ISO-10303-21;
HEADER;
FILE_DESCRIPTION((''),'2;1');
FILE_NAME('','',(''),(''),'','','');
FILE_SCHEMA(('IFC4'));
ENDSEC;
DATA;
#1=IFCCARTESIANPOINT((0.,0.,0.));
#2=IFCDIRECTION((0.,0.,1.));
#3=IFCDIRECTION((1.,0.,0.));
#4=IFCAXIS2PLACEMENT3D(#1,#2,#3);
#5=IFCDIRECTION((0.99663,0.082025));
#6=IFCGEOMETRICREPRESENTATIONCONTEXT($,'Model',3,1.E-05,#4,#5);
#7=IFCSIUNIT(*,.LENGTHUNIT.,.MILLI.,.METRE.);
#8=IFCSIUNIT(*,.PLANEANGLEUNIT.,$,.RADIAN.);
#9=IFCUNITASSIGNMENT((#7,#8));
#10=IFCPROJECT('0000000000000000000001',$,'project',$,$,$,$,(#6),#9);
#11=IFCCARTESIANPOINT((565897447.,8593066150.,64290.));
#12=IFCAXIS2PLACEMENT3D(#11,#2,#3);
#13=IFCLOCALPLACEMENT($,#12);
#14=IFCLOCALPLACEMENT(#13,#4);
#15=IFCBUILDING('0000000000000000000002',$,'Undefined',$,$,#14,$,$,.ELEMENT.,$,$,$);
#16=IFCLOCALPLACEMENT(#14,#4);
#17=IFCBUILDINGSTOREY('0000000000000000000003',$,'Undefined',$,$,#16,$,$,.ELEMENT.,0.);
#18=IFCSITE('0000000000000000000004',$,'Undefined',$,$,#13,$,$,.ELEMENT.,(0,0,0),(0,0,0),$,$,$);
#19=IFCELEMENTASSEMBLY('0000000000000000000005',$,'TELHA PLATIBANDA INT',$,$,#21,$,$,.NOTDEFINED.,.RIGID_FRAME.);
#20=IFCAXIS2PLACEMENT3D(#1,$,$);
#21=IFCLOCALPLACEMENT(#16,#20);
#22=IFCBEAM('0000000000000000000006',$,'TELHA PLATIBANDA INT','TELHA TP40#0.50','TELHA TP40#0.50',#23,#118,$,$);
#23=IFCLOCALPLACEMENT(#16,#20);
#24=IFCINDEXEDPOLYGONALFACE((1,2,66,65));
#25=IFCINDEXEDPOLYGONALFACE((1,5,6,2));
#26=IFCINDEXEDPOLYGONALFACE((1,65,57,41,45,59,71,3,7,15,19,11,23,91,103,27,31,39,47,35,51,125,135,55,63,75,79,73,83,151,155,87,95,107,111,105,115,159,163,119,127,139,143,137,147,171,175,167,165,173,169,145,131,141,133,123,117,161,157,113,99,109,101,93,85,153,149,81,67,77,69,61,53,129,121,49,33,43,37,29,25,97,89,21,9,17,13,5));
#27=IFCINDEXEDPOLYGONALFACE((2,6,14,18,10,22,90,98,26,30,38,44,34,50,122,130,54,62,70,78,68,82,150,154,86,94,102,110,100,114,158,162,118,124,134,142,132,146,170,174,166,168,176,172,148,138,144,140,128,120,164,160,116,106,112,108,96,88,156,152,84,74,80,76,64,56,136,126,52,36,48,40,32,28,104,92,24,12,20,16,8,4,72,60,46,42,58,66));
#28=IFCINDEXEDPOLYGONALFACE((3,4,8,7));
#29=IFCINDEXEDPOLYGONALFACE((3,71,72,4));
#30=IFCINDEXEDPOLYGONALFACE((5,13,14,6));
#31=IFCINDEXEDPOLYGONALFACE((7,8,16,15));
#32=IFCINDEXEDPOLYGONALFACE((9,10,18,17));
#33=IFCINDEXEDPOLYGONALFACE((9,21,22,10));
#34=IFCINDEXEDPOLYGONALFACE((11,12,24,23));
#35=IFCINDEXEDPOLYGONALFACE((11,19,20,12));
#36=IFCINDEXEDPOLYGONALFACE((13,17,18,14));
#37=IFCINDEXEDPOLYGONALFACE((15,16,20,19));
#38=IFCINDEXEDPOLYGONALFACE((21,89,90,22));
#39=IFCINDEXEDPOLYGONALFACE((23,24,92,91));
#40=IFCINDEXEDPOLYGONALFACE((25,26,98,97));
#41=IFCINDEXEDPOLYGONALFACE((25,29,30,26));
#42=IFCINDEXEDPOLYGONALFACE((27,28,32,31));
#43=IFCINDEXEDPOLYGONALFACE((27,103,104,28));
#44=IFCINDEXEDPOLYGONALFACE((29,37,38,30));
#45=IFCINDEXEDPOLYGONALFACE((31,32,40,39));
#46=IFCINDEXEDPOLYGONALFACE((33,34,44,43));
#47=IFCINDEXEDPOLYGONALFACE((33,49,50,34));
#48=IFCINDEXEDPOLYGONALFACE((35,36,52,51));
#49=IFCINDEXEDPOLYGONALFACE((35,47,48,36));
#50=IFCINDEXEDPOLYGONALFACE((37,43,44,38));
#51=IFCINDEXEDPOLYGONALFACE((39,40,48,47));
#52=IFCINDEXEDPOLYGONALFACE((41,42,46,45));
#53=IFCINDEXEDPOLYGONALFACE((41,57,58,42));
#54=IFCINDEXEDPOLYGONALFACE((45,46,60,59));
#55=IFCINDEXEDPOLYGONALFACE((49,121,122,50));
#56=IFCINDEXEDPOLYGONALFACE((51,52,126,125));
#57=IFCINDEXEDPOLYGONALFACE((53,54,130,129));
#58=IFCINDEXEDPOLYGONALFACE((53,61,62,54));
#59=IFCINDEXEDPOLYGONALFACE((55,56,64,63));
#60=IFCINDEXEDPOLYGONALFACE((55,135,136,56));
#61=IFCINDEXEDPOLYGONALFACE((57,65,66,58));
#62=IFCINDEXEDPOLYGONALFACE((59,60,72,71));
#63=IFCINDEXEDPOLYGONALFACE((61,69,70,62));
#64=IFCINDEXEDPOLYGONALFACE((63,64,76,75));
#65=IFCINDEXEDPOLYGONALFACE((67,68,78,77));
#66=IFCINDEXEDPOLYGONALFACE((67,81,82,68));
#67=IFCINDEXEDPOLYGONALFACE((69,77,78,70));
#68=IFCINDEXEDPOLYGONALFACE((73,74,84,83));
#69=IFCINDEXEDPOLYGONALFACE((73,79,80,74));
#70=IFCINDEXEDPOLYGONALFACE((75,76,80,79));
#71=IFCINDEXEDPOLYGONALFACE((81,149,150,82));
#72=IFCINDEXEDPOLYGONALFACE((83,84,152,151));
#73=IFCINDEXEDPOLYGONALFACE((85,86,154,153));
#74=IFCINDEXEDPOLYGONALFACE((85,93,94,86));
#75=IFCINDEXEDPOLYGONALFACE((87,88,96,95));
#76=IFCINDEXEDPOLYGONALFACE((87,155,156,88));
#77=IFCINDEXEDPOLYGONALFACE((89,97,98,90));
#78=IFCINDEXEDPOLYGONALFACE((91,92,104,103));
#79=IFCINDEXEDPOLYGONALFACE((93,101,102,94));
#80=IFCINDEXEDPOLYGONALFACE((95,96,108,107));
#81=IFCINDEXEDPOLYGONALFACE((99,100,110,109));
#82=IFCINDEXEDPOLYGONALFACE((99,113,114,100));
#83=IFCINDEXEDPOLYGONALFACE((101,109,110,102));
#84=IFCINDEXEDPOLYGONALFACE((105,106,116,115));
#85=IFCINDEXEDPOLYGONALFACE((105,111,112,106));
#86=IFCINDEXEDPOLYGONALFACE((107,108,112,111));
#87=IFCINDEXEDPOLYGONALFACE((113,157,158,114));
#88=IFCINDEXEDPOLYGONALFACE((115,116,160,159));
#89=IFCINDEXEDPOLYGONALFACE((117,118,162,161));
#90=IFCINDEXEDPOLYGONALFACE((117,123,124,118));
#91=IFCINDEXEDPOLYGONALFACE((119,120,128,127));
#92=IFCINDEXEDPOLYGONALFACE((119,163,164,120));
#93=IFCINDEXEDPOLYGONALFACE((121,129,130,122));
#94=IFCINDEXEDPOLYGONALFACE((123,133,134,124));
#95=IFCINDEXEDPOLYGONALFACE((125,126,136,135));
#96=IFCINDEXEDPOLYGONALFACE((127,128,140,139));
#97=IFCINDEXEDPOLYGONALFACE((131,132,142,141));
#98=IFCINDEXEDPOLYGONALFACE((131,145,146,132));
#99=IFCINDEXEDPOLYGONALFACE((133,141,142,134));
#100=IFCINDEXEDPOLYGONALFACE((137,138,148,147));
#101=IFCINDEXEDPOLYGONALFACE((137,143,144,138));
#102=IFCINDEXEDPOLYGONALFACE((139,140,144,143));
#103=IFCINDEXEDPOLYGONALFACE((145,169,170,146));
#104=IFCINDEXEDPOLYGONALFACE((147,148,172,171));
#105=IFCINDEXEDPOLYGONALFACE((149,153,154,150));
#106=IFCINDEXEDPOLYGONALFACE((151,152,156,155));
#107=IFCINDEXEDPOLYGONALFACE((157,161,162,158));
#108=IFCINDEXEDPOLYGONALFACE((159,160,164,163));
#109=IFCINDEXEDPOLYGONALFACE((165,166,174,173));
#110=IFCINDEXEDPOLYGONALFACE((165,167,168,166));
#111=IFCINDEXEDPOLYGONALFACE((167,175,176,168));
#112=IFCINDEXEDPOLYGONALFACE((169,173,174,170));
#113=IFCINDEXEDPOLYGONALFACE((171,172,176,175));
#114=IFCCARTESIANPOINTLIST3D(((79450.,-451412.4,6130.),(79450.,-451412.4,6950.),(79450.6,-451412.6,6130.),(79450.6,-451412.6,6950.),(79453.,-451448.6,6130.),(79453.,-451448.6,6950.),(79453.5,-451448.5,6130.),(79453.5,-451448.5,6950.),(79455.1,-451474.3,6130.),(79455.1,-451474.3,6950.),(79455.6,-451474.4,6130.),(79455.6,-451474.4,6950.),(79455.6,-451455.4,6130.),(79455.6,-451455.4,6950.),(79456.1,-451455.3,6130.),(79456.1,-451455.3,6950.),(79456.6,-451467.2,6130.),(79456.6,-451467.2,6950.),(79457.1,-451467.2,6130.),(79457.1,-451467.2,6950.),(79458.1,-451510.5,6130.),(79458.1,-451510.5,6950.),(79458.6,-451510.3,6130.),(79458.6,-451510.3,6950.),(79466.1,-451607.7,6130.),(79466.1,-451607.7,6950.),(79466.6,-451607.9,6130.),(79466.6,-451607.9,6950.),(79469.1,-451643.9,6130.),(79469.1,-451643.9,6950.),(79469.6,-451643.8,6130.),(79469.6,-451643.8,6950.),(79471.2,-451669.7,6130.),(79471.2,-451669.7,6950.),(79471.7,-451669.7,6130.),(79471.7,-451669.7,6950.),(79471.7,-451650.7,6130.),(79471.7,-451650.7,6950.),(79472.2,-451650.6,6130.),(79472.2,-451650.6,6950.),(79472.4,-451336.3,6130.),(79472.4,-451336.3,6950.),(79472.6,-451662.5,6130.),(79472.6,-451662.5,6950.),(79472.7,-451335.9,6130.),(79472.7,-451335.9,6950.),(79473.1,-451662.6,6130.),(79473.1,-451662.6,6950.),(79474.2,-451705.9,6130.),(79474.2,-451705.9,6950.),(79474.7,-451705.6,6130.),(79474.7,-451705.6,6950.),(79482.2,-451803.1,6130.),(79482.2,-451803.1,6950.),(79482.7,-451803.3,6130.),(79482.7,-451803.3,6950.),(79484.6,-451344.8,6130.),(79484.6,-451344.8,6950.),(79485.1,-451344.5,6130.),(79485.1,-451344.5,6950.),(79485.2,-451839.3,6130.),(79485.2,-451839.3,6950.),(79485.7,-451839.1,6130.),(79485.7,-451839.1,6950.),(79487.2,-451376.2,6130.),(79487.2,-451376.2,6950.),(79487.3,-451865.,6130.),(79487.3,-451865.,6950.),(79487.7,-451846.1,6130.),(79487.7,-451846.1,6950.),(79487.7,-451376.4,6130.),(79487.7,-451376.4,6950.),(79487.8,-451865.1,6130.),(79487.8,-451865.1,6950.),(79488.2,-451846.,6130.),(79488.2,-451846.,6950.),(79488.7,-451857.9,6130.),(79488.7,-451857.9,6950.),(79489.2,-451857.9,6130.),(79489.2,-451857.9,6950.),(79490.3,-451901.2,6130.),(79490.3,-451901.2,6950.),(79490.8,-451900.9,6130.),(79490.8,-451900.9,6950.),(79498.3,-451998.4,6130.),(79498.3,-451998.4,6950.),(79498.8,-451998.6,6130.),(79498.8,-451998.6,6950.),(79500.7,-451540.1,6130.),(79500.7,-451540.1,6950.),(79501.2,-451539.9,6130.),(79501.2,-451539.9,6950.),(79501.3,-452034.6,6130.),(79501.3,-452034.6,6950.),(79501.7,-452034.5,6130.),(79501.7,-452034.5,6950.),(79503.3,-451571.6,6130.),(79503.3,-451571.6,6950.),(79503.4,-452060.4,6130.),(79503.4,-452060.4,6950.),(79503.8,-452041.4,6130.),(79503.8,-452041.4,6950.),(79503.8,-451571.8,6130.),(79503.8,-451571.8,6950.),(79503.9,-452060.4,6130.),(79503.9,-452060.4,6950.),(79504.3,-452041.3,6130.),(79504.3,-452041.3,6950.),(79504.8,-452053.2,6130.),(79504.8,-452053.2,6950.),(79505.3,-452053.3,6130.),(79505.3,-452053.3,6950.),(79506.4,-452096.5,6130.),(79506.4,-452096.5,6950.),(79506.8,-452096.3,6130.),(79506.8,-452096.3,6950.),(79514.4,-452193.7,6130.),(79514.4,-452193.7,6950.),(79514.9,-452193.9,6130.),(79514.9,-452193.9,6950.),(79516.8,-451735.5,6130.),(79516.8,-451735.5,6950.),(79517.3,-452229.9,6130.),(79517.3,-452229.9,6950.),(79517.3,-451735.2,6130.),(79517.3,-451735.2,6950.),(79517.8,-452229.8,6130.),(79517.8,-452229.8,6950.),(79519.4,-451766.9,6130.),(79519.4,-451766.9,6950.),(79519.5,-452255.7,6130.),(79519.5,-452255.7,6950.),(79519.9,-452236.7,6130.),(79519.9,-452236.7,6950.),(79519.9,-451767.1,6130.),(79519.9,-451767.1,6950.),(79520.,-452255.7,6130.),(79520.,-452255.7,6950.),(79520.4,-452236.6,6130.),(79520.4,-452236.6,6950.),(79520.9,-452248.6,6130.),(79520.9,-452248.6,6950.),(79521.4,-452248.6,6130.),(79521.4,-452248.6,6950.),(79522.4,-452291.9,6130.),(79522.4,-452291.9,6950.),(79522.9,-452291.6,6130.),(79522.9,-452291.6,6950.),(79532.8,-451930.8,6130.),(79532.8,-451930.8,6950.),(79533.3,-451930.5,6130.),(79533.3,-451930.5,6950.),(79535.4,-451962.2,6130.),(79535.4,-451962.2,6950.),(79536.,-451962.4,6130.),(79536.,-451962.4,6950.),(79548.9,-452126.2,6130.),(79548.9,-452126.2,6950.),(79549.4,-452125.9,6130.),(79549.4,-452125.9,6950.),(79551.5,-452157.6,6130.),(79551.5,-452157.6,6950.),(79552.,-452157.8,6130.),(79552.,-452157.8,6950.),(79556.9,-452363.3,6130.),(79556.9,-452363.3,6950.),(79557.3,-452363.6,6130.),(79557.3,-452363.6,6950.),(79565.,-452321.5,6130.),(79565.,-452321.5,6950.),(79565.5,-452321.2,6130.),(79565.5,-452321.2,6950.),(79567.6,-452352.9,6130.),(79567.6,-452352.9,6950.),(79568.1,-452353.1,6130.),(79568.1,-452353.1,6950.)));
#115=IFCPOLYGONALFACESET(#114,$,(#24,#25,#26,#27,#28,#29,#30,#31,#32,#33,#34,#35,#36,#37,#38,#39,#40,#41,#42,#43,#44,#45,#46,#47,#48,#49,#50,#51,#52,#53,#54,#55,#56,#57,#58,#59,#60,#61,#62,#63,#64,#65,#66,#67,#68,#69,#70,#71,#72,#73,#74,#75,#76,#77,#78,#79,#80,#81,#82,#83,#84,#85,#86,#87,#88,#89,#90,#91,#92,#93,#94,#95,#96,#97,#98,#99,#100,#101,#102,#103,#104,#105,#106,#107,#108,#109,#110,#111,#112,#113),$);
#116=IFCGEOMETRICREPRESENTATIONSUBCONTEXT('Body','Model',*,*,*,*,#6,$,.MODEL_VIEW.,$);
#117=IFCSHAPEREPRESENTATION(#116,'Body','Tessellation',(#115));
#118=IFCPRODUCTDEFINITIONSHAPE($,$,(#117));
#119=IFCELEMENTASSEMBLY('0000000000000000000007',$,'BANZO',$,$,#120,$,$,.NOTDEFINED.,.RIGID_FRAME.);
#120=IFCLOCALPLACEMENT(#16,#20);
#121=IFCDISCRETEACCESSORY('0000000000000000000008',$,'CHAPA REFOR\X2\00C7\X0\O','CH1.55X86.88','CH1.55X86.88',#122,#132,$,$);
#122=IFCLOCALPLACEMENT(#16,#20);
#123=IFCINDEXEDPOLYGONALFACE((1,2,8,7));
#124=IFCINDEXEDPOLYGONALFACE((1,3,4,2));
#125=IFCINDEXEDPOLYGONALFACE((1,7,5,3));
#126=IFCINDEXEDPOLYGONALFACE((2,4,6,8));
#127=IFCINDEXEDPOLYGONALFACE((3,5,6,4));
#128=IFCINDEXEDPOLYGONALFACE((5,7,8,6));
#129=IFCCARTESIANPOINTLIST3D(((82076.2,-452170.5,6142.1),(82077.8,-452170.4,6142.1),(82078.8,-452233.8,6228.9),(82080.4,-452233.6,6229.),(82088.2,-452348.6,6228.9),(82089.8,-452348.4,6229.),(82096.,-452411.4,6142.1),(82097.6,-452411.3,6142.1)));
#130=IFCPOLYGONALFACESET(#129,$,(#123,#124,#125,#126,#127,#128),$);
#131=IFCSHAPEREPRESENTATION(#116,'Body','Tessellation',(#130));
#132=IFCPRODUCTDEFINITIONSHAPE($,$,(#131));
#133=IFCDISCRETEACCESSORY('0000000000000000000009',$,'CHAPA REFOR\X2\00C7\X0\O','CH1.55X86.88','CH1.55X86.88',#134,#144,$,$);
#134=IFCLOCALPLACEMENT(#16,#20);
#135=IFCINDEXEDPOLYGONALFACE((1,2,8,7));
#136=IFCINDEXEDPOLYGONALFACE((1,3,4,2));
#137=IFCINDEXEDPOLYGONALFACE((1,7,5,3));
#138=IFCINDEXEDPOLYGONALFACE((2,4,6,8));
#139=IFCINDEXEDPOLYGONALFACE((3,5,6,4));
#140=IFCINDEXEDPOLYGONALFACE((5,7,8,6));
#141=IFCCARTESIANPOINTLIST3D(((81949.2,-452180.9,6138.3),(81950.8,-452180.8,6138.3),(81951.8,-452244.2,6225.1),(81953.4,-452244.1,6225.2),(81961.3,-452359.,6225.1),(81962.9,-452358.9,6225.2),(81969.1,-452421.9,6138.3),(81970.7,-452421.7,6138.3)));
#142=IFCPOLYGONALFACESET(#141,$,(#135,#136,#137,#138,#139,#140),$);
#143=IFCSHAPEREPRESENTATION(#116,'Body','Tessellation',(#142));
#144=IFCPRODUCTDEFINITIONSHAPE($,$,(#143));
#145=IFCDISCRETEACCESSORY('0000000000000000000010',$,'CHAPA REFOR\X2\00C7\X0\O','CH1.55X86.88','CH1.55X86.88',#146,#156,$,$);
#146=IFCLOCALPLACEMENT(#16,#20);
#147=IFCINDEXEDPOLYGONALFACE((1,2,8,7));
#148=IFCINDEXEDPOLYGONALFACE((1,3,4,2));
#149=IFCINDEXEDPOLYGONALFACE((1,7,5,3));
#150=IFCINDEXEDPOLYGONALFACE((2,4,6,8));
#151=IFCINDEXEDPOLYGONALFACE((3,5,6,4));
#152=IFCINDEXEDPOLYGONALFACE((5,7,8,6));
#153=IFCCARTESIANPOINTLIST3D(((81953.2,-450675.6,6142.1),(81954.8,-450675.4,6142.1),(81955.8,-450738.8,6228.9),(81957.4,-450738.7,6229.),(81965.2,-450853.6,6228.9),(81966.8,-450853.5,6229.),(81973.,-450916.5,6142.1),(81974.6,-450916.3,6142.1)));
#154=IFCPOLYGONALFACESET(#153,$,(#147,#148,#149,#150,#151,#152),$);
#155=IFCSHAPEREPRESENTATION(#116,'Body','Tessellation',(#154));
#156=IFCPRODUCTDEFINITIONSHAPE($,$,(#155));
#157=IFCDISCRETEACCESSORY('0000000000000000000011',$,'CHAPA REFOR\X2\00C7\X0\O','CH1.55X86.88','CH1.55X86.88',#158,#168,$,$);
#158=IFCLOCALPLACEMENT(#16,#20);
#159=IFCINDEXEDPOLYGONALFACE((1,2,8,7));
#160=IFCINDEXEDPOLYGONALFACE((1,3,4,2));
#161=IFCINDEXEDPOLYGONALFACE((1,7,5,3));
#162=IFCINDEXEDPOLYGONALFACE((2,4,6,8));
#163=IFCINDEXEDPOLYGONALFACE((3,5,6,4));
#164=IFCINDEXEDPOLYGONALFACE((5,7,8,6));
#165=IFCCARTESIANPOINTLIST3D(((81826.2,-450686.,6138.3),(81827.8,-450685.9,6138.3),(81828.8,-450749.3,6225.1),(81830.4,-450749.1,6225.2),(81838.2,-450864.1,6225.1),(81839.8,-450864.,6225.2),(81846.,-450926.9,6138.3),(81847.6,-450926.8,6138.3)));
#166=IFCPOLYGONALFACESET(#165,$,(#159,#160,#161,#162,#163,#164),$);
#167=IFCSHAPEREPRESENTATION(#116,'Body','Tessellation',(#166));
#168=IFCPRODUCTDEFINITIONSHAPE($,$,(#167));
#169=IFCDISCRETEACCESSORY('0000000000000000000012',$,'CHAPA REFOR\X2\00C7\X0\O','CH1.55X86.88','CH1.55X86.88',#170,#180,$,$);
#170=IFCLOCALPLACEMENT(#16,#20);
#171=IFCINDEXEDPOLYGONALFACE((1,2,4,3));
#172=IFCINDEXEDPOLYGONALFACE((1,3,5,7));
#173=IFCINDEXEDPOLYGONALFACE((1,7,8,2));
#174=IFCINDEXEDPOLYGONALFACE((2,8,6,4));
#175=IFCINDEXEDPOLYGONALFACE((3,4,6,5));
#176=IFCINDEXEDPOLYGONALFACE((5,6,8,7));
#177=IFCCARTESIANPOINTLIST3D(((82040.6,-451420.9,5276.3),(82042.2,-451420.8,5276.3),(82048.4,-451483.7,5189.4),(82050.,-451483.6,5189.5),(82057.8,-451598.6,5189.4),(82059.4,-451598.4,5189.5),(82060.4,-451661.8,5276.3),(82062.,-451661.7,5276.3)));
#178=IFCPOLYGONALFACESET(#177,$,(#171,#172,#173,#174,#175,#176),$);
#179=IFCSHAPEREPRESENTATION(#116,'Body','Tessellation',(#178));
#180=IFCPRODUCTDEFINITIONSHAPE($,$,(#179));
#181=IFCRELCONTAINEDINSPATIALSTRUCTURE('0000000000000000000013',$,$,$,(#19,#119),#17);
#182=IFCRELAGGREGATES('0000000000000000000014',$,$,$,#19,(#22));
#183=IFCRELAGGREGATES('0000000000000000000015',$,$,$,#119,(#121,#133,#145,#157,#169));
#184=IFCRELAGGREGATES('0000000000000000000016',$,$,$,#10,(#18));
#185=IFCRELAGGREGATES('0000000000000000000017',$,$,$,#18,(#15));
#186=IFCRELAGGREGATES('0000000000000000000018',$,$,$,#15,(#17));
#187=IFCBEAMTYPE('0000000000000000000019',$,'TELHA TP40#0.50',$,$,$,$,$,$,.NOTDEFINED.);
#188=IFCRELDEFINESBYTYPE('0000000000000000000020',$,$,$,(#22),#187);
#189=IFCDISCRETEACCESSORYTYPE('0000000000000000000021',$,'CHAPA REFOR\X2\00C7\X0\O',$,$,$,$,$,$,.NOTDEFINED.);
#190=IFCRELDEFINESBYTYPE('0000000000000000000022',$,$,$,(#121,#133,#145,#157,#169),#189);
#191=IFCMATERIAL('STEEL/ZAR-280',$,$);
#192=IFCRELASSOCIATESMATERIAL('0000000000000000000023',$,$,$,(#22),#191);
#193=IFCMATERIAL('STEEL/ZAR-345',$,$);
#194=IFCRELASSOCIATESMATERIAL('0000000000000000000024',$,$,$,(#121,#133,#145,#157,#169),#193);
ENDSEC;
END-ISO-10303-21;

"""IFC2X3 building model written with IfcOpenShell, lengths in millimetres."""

from ifc_helpers import new_model, si_unit, direction, frame, origin_with_axes, place, context, subcontext, project, spatial, polyline, outline, extrude, material, type_object, element, aggregate, save


model = new_model("IFC2X3")

# Units and contexts
model_context = context("Model", 3, precision=1e-05, world=origin_with_axes(), true_north=direction((0.99663, 0.082025)))
body_context = subcontext(model_context, "Body", "Model", "MODEL_VIEW")
ifc_project = project(units=[si_unit("LENGTHUNIT", "METRE", prefix="MILLI"), si_unit("PLANEANGLEUNIT", "RADIAN")], contexts=[model_context])

# Site, building, storey
site_placement = place(None, frame((565897447.0, 8593066150.0, 64290.0), z_axis=(0.0, 0.0, 1.0), x_axis=(1.0, 0.0, 0.0)))
site = spatial("IfcSite", under=ifc_project, at=site_placement, Name="Undefined", CompositionType="ELEMENT", RefLatitude=(0, 0, 0), RefLongitude=(0, 0, 0))
building_placement = place(site_placement, origin_with_axes())
building = spatial("IfcBuilding", under=site, at=building_placement, Name="Undefined", CompositionType="ELEMENT")
storey_placement = place(building_placement, origin_with_axes())
storey = spatial("IfcBuildingStorey", under=building, at=storey_placement, Name="Undefined", CompositionType="ELEMENT", Elevation=0.0)

# Element assembly, beam
ifc_material_1 = material(Name="STEEL/ZAR-280")
beam_type_1 = type_object("IfcBeamType", Name="TELHA TP40#0.50", PredefinedType="NOTDEFINED")
assembly_1_placement = place(storey_placement, origin_with_axes())
assembly_1 = element("IfcElementAssembly", 1, at=assembly_1_placement, inside=storey, Name="TELHA PLATIBANDA INT", AssemblyPlace="NOTDEFINED", PredefinedType="RIGID_FRAME")
beam_1_placement = place(assembly_1_placement, frame((79506.4, -451850.7, 6950.0), z_axis=(0.99663, 0.082025, 0.0), x_axis=(0.0, 0.0, -1.0)))
beam_1 = element("IfcBeam", 2, at=beam_1_placement, type_object=beam_type_1, material=ifc_material_1, Name="TELHA PLATIBANDA INT", Description="TELHA TP40#0.50", ObjectType="TELHA TP40#0.50", context=body_context, shape_type="SweptSolid", body=[
    extrude(outline(polyline([(440.8, -19.8), (473.8, 20.2), (505.8, 20.2), (515.4, 8.6), (515.0, 8.3), (505.6, 19.8), (474.0, 19.8), (441.0, -20.2), (404.7, -20.2), (397.7, -18.2), (385.9, -18.2), (378.9, -20.2), (342.6, -20.2), (309.6, 19.8), (278.0, 19.8), (245.0, -20.2), (208.7, -20.2), (201.7, -18.2), (189.9, -18.2), (182.9, -20.2), (146.6, -20.2), (113.6, 19.8), (82.0, 19.8), (49.0, -20.2), (12.7, -20.2), (5.7, -18.2), (-6.1, -18.2), (-13.1, -20.2), (-49.4, -20.2), (-82.4, 19.8), (-114.0, 19.8), (-147.0, -20.2), (-183.3, -20.2), (-190.3, -18.2), (-202.1, -18.2), (-209.1, -20.2), (-245.4, -20.2), (-278.4, 19.8), (-310.0, 19.8), (-343.0, -20.2), (-379.3, -20.2), (-386.3, -18.2), (-398.1, -18.2), (-405.1, -20.2), (-441.4, -20.2), (-474.4, 19.8), (-506.0, 19.8), (-515.4, 8.3), (-515.8, 8.6), (-506.2, 20.2), (-474.2, 20.2), (-441.2, -19.8), (-405.2, -19.8), (-398.2, -17.8), (-386.2, -17.8), (-379.2, -19.8), (-343.2, -19.8), (-310.2, 20.2), (-278.2, 20.2), (-245.2, -19.8), (-209.2, -19.8), (-202.2, -17.8), (-190.2, -17.8), (-183.2, -19.8), (-147.2, -19.8), (-114.2, 20.2), (-82.2, 20.2), (-49.2, -19.8), (-13.2, -19.8), (-6.2, -17.8), (5.8, -17.8), (12.8, -19.8), (48.8, -19.8), (81.8, 20.2), (113.8, 20.2), (146.8, -19.8), (182.8, -19.8), (189.8, -17.8), (201.8, -17.8), (208.8, -19.8), (244.8, -19.8), (277.8, 20.2), (309.8, 20.2), (342.8, -19.8), (378.8, -19.8), (385.8, -17.8), (397.8, -17.8), (404.8, -19.8), (440.8, -19.8)])), frame((820.0, 0.0, 0.0), z_axis=(-1.0, 0.0, 0.0), x_axis=(0.0, -1.0, 0.0)), (0.0, 0.0, 1.0), 820.0),
])
aggregate(assembly_1, [beam_1])

# Element assembly, discrete accessories
assembly_2_placement = place(storey_placement, origin_with_axes())
assembly_2 = element("IfcElementAssembly", 3, at=assembly_2_placement, inside=storey, Name="BANZO", AssemblyPlace="NOTDEFINED", PredefinedType="RIGID_FRAME")
ifc_material_2 = material(Name="STEEL/ZAR-345")
discrete_accessory_type_1 = type_object("IfcDiscreteAccessoryType", Name="CHAPA REFORÇO")
discrete_accessory_1_placement = place(assembly_2_placement, frame((82096.8, -452411.4, 6142.1), z_axis=(0.996182, 0.081989, 0.029987), x_axis=(-0.082025, 0.99663, 0.0)))
discrete_accessory_1 = element("IfcDiscreteAccessory", 4, at=discrete_accessory_1_placement, type_object=discrete_accessory_type_1, material=ifc_material_2, Name="CHAPA REFORÇO", Description="CH1.55X86.88", ObjectType="CH1.55X86.88", context=body_context, shape_type="SweptSolid", body=[
    extrude(outline(polyline([(0.0, 0.0), (241.7, 0.0), (178.5, 86.9), (63.3, 86.9), (0.0, 0.0)])), frame((0.0, 0.0, -0.8), z_axis=(0.0, 0.0, 1.0), x_axis=(1.0, 0.0, 0.0)), (0.0, 0.0, 1.0), 1.6),
])
discrete_accessory_2_placement = place(assembly_2_placement, frame((81969.9, -452421.8, 6138.3), z_axis=(0.996182, 0.081989, 0.029987), x_axis=(-0.082025, 0.99663, 0.0)))
discrete_accessory_2 = element("IfcDiscreteAccessory", 5, at=discrete_accessory_2_placement, type_object=discrete_accessory_type_1, material=ifc_material_2, Name="CHAPA REFORÇO", Description="CH1.55X86.88", ObjectType="CH1.55X86.88", context=body_context, shape_type="SweptSolid", body=[
    extrude(outline(polyline([(0.0, 0.0), (241.7, 0.0), (178.5, 86.9), (63.3, 86.9), (0.0, 0.0)])), frame((0.0, 0.0, -0.8), z_axis=(0.0, 0.0, 1.0), x_axis=(1.0, 0.0, 0.0)), (0.0, 0.0, 1.0), 1.6),
])
discrete_accessory_3_placement = place(assembly_2_placement, frame((81973.8, -450916.4, 6142.1), z_axis=(0.996182, 0.081989, 0.029987), x_axis=(-0.082025, 0.99663, 0.0)))
discrete_accessory_3 = element("IfcDiscreteAccessory", 6, at=discrete_accessory_3_placement, type_object=discrete_accessory_type_1, material=ifc_material_2, Name="CHAPA REFORÇO", Description="CH1.55X86.88", ObjectType="CH1.55X86.88", context=body_context, shape_type="SweptSolid", body=[
    extrude(outline(polyline([(0.0, 0.0), (241.7, 0.0), (178.5, 86.9), (63.3, 86.9), (0.0, 0.0)])), frame((0.0, 0.0, -0.8), z_axis=(0.0, 0.0, 1.0), x_axis=(1.0, 0.0, 0.0)), (0.0, 0.0, 1.0), 1.6),
])
discrete_accessory_4_placement = place(assembly_2_placement, frame((81846.8, -450926.9, 6138.3), z_axis=(0.996182, 0.081989, 0.029987), x_axis=(-0.082025, 0.99663, 0.0)))
discrete_accessory_4 = element("IfcDiscreteAccessory", 7, at=discrete_accessory_4_placement, type_object=discrete_accessory_type_1, material=ifc_material_2, Name="CHAPA REFORÇO", Description="CH1.55X86.88", ObjectType="CH1.55X86.88", context=body_context, shape_type="SweptSolid", body=[
    extrude(outline(polyline([(0.0, 0.0), (241.7, 0.0), (178.5, 86.9), (63.3, 86.9), (0.0, 0.0)])), frame((0.0, 0.0, -0.8), z_axis=(0.0, 0.0, 1.0), x_axis=(1.0, 0.0, 0.0)), (0.0, 0.0, 1.0), 1.6),
])
discrete_accessory_5_placement = place(assembly_2_placement, frame((82041.4, -451420.8, 5276.3), z_axis=(0.996182, 0.081989, 0.029987), x_axis=(0.082025, -0.99663, 0.0)))
discrete_accessory_5 = element("IfcDiscreteAccessory", 8, at=discrete_accessory_5_placement, type_object=discrete_accessory_type_1, material=ifc_material_2, Name="CHAPA REFORÇO", Description="CH1.55X86.88", ObjectType="CH1.55X86.88", context=body_context, shape_type="SweptSolid", body=[
    extrude(outline(polyline([(0.0, 0.0), (241.7, 0.0), (178.5, 86.9), (63.3, 86.9), (0.0, 0.0)])), frame((0.0, 0.0, -0.8), z_axis=(0.0, 0.0, 1.0), x_axis=(1.0, 0.0, 0.0)), (0.0, 0.0, 1.0), 1.6),
])
aggregate(assembly_2, [discrete_accessory_1, discrete_accessory_2, discrete_accessory_3, discrete_accessory_4, discrete_accessory_5])

save(model, "model.ifc")
